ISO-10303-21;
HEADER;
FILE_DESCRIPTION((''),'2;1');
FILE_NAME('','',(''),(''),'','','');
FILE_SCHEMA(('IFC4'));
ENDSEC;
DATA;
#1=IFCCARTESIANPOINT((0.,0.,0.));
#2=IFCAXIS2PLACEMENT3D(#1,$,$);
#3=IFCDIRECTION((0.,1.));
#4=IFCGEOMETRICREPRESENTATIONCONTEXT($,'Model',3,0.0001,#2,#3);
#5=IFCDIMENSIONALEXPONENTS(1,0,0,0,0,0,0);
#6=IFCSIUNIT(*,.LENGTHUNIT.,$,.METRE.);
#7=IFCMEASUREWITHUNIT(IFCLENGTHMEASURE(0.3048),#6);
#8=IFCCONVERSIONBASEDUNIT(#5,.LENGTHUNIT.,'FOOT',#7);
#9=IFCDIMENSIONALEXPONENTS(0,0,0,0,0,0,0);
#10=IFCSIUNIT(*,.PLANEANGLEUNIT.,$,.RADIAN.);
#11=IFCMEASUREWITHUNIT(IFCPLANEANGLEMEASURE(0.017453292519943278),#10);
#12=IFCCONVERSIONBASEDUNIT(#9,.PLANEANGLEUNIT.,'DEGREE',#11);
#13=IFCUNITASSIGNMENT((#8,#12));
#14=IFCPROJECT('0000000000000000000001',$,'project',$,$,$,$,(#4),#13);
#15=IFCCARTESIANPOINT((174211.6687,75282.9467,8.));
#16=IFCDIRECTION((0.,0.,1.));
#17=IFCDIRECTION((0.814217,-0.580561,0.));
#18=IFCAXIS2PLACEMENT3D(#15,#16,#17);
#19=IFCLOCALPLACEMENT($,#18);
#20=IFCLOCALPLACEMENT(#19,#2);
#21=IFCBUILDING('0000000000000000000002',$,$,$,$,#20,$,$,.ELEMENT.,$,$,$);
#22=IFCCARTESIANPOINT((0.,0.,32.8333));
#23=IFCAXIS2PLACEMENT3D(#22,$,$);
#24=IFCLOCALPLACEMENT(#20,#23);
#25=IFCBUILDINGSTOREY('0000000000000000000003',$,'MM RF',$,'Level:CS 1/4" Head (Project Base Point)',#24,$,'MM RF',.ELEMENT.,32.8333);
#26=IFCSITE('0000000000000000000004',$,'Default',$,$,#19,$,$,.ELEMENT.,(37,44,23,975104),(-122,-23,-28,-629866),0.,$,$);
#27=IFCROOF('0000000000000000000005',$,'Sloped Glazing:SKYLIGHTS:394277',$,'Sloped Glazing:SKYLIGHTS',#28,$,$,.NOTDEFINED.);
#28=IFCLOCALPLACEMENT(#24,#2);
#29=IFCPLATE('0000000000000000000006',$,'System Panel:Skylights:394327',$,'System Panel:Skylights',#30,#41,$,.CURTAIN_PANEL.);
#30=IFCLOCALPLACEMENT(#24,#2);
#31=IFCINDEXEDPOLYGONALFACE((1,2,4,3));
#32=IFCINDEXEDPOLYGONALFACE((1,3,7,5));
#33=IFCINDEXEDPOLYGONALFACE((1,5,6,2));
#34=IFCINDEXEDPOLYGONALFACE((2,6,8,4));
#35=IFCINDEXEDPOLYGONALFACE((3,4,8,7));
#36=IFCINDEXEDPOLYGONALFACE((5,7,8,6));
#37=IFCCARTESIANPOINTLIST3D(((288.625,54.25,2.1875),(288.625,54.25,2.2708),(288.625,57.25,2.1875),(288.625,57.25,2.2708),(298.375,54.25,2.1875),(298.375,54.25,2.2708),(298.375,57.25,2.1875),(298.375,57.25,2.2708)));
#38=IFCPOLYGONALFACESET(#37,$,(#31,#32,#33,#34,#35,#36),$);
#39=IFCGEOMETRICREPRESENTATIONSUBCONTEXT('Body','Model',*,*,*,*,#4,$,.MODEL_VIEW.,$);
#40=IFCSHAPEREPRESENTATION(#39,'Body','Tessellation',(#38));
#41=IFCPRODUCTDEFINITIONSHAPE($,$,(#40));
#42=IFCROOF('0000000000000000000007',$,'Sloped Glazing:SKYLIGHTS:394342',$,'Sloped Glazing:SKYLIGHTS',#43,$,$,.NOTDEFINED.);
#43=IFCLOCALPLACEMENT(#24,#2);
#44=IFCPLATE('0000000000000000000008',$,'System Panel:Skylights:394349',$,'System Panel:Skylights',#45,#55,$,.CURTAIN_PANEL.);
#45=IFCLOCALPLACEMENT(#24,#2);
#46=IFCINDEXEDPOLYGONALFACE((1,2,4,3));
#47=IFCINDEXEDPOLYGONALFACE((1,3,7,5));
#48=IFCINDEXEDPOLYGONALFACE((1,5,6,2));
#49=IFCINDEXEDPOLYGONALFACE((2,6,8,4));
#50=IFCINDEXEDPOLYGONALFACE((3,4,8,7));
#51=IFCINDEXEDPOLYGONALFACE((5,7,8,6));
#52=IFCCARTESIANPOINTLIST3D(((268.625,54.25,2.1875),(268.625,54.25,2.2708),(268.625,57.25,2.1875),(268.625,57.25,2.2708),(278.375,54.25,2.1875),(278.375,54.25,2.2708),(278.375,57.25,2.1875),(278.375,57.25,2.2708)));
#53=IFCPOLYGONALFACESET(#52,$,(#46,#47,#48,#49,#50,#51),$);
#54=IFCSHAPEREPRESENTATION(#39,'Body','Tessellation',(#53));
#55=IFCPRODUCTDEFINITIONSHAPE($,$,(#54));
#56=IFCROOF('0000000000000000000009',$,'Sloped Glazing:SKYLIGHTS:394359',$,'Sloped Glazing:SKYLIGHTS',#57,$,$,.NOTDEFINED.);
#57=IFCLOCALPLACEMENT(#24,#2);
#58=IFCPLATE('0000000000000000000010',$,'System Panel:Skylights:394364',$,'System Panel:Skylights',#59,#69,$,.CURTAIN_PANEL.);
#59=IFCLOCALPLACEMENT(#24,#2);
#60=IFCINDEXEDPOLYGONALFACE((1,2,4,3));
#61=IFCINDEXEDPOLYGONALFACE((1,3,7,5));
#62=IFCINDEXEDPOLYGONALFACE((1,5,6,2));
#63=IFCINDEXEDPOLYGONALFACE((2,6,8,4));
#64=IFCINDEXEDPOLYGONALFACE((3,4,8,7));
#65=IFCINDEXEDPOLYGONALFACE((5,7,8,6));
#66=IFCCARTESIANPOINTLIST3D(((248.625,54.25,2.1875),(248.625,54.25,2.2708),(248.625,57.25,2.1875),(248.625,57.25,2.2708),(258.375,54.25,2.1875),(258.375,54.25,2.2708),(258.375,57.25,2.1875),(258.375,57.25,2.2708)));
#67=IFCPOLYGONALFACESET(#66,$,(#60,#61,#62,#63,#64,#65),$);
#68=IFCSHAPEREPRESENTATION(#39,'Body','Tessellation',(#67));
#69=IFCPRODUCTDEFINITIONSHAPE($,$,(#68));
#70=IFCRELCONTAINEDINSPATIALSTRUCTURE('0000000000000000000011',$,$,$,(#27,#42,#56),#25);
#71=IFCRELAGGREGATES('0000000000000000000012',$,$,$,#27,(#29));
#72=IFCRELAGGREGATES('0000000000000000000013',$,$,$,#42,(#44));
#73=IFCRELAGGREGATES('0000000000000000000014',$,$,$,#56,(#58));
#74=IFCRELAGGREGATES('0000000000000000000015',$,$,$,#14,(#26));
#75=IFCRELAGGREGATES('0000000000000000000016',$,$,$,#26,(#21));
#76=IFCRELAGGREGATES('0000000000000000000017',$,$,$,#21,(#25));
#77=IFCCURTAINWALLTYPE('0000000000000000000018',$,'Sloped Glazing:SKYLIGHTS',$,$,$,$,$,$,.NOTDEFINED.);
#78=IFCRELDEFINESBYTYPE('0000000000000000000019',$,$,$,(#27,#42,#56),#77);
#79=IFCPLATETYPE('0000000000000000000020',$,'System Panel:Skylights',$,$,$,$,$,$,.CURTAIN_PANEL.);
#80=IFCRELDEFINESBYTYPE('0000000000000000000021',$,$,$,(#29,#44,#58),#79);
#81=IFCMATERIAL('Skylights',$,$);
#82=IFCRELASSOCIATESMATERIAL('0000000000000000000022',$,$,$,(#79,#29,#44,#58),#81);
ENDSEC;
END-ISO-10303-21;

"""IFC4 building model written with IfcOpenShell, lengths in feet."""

from ifc_helpers import new_model, entity, si_unit, converted_unit, direction, frame, origin, place, context, subcontext, project, spatial, indexed_curve, outline, extrude, source, transform, mapped, material, type_object, type_shapes, element, aggregate, save


model = new_model("IFC4")

# Units and contexts
model_context = context("Model", 3, precision=0.0001, world=origin(), true_north=direction((0.0, 1.0)))
body_context = subcontext(model_context, "Body", "Model", "MODEL_VIEW")
ifc_project = project(units=[converted_unit("LENGTHUNIT", "FOOT", entity("IfcLengthMeasure", 0.3048), si_unit("LENGTHUNIT", "METRE"), dimensions=[1, 0, 0, 0, 0, 0, 0]), converted_unit("PLANEANGLEUNIT", "DEGREE", entity("IfcPlaneAngleMeasure", 0.017453292519943278), si_unit("PLANEANGLEUNIT", "RADIAN"), dimensions=[0, 0, 0, 0, 0, 0, 0])], contexts=[model_context])

# Site, building, storey
site_placement = place(None, frame((174211.6687, 75282.9467, 8.0), z_axis=(0.0, 0.0, 1.0), x_axis=(0.814217, -0.580561, 0.0)))
site = spatial("IfcSite", under=ifc_project, at=site_placement, Name="Default", CompositionType="ELEMENT", RefLatitude=(37, 44, 23, 975104), RefLongitude=(-122, -23, -28, -629866), RefElevation=0.0)
building_placement = place(site_placement, origin())
building = spatial("IfcBuilding", under=site, at=building_placement, CompositionType="ELEMENT")
storey_placement = place(building_placement, frame((0.0, 0.0, 32.8333)))
storey = spatial("IfcBuildingStorey", under=building, at=storey_placement, Name="MM RF", ObjectType="Level:CS 1/4\" Head (Project Base Point)", LongName="MM RF", CompositionType="ELEMENT", Elevation=32.8333)

# Roofs, plates
curtain_wall_type_1 = type_object("IfcCurtainWallType", Name="Sloped Glazing:SKYLIGHTS", PredefinedType="NOTDEFINED")
roof_1_placement = place(storey_placement, frame((0.0, 0.0, -32.8333)))
roof_1 = element("IfcRoof", 1, at=roof_1_placement, inside=storey, type_object=curtain_wall_type_1, Name="Sloped Glazing:SKYLIGHTS:394277", ObjectType="Sloped Glazing:SKYLIGHTS", PredefinedType="NOTDEFINED")
ifc_material_1 = material(Name="Skylights")
plate_type_1 = type_object("IfcPlateType", Name="System Panel:Skylights", PredefinedType="CURTAIN_PANEL", material=ifc_material_1)
shared_shape_1 = source(origin(), body_context, "Body", "SweptSolid", [
    extrude(outline(indexed_curve([(-0.0417, -4.875), (0.0417, -4.875), (0.0417, 4.875), (-0.0417, 4.875), (-0.0417, -4.875)], self_intersect=False)), frame((0.0, 0.1042, 0.0), z_axis=(0.0, 0.0, 1.0), x_axis=(0.0, 1.0, 0.0)), (0.0, 0.0, 1.0), 3.0),
])
type_shapes(plate_type_1, [shared_shape_1])
plate_1_placement = place(roof_1_placement, frame((293.5, 54.25, 35.1667), z_axis=(0.0, 1.0, 0.0), x_axis=(1.0, 0.0, 0.0)))
plate_1 = element("IfcPlate", 2, at=plate_1_placement, type_object=plate_type_1, material=ifc_material_1, Name="System Panel:Skylights:394327", ObjectType="System Panel:Skylights", PredefinedType="CURTAIN_PANEL", context=body_context, shape_type="MappedRepresentation", body=[
    mapped(shared_shape_1, transform((0.0, 0.0, 0.0), scale=1.0)),
])
aggregate(roof_1, [plate_1])
roof_2_placement = place(storey_placement, frame((0.0, 0.0, -32.8333)))
roof_2 = element("IfcRoof", 3, at=roof_2_placement, inside=storey, type_object=curtain_wall_type_1, Name="Sloped Glazing:SKYLIGHTS:394342", ObjectType="Sloped Glazing:SKYLIGHTS", PredefinedType="NOTDEFINED")
plate_2_placement = place(roof_2_placement, frame((273.5, 54.25, 35.1667), z_axis=(0.0, 1.0, 0.0), x_axis=(1.0, 0.0, 0.0)))
plate_2 = element("IfcPlate", 4, at=plate_2_placement, type_object=plate_type_1, material=ifc_material_1, Name="System Panel:Skylights:394349", ObjectType="System Panel:Skylights", PredefinedType="CURTAIN_PANEL", context=body_context, shape_type="MappedRepresentation", body=[
    mapped(shared_shape_1, transform((0.0, 0.0, 0.0), scale=1.0)),
])
aggregate(roof_2, [plate_2])
roof_3_placement = place(storey_placement, frame((0.0, 0.0, -32.8333)))
roof_3 = element("IfcRoof", 5, at=roof_3_placement, inside=storey, type_object=curtain_wall_type_1, Name="Sloped Glazing:SKYLIGHTS:394359", ObjectType="Sloped Glazing:SKYLIGHTS", PredefinedType="NOTDEFINED")
plate_3_placement = place(roof_3_placement, frame((253.5, 54.25, 35.1667), z_axis=(0.0, 1.0, 0.0), x_axis=(1.0, 0.0, 0.0)))
plate_3 = element("IfcPlate", 6, at=plate_3_placement, type_object=plate_type_1, material=ifc_material_1, Name="System Panel:Skylights:394364", ObjectType="System Panel:Skylights", PredefinedType="CURTAIN_PANEL", context=body_context, shape_type="MappedRepresentation", body=[
    mapped(shared_shape_1, transform((0.0, 0.0, 0.0), scale=1.0)),
])
aggregate(roof_3, [plate_3])

save(model, "model.ifc")
